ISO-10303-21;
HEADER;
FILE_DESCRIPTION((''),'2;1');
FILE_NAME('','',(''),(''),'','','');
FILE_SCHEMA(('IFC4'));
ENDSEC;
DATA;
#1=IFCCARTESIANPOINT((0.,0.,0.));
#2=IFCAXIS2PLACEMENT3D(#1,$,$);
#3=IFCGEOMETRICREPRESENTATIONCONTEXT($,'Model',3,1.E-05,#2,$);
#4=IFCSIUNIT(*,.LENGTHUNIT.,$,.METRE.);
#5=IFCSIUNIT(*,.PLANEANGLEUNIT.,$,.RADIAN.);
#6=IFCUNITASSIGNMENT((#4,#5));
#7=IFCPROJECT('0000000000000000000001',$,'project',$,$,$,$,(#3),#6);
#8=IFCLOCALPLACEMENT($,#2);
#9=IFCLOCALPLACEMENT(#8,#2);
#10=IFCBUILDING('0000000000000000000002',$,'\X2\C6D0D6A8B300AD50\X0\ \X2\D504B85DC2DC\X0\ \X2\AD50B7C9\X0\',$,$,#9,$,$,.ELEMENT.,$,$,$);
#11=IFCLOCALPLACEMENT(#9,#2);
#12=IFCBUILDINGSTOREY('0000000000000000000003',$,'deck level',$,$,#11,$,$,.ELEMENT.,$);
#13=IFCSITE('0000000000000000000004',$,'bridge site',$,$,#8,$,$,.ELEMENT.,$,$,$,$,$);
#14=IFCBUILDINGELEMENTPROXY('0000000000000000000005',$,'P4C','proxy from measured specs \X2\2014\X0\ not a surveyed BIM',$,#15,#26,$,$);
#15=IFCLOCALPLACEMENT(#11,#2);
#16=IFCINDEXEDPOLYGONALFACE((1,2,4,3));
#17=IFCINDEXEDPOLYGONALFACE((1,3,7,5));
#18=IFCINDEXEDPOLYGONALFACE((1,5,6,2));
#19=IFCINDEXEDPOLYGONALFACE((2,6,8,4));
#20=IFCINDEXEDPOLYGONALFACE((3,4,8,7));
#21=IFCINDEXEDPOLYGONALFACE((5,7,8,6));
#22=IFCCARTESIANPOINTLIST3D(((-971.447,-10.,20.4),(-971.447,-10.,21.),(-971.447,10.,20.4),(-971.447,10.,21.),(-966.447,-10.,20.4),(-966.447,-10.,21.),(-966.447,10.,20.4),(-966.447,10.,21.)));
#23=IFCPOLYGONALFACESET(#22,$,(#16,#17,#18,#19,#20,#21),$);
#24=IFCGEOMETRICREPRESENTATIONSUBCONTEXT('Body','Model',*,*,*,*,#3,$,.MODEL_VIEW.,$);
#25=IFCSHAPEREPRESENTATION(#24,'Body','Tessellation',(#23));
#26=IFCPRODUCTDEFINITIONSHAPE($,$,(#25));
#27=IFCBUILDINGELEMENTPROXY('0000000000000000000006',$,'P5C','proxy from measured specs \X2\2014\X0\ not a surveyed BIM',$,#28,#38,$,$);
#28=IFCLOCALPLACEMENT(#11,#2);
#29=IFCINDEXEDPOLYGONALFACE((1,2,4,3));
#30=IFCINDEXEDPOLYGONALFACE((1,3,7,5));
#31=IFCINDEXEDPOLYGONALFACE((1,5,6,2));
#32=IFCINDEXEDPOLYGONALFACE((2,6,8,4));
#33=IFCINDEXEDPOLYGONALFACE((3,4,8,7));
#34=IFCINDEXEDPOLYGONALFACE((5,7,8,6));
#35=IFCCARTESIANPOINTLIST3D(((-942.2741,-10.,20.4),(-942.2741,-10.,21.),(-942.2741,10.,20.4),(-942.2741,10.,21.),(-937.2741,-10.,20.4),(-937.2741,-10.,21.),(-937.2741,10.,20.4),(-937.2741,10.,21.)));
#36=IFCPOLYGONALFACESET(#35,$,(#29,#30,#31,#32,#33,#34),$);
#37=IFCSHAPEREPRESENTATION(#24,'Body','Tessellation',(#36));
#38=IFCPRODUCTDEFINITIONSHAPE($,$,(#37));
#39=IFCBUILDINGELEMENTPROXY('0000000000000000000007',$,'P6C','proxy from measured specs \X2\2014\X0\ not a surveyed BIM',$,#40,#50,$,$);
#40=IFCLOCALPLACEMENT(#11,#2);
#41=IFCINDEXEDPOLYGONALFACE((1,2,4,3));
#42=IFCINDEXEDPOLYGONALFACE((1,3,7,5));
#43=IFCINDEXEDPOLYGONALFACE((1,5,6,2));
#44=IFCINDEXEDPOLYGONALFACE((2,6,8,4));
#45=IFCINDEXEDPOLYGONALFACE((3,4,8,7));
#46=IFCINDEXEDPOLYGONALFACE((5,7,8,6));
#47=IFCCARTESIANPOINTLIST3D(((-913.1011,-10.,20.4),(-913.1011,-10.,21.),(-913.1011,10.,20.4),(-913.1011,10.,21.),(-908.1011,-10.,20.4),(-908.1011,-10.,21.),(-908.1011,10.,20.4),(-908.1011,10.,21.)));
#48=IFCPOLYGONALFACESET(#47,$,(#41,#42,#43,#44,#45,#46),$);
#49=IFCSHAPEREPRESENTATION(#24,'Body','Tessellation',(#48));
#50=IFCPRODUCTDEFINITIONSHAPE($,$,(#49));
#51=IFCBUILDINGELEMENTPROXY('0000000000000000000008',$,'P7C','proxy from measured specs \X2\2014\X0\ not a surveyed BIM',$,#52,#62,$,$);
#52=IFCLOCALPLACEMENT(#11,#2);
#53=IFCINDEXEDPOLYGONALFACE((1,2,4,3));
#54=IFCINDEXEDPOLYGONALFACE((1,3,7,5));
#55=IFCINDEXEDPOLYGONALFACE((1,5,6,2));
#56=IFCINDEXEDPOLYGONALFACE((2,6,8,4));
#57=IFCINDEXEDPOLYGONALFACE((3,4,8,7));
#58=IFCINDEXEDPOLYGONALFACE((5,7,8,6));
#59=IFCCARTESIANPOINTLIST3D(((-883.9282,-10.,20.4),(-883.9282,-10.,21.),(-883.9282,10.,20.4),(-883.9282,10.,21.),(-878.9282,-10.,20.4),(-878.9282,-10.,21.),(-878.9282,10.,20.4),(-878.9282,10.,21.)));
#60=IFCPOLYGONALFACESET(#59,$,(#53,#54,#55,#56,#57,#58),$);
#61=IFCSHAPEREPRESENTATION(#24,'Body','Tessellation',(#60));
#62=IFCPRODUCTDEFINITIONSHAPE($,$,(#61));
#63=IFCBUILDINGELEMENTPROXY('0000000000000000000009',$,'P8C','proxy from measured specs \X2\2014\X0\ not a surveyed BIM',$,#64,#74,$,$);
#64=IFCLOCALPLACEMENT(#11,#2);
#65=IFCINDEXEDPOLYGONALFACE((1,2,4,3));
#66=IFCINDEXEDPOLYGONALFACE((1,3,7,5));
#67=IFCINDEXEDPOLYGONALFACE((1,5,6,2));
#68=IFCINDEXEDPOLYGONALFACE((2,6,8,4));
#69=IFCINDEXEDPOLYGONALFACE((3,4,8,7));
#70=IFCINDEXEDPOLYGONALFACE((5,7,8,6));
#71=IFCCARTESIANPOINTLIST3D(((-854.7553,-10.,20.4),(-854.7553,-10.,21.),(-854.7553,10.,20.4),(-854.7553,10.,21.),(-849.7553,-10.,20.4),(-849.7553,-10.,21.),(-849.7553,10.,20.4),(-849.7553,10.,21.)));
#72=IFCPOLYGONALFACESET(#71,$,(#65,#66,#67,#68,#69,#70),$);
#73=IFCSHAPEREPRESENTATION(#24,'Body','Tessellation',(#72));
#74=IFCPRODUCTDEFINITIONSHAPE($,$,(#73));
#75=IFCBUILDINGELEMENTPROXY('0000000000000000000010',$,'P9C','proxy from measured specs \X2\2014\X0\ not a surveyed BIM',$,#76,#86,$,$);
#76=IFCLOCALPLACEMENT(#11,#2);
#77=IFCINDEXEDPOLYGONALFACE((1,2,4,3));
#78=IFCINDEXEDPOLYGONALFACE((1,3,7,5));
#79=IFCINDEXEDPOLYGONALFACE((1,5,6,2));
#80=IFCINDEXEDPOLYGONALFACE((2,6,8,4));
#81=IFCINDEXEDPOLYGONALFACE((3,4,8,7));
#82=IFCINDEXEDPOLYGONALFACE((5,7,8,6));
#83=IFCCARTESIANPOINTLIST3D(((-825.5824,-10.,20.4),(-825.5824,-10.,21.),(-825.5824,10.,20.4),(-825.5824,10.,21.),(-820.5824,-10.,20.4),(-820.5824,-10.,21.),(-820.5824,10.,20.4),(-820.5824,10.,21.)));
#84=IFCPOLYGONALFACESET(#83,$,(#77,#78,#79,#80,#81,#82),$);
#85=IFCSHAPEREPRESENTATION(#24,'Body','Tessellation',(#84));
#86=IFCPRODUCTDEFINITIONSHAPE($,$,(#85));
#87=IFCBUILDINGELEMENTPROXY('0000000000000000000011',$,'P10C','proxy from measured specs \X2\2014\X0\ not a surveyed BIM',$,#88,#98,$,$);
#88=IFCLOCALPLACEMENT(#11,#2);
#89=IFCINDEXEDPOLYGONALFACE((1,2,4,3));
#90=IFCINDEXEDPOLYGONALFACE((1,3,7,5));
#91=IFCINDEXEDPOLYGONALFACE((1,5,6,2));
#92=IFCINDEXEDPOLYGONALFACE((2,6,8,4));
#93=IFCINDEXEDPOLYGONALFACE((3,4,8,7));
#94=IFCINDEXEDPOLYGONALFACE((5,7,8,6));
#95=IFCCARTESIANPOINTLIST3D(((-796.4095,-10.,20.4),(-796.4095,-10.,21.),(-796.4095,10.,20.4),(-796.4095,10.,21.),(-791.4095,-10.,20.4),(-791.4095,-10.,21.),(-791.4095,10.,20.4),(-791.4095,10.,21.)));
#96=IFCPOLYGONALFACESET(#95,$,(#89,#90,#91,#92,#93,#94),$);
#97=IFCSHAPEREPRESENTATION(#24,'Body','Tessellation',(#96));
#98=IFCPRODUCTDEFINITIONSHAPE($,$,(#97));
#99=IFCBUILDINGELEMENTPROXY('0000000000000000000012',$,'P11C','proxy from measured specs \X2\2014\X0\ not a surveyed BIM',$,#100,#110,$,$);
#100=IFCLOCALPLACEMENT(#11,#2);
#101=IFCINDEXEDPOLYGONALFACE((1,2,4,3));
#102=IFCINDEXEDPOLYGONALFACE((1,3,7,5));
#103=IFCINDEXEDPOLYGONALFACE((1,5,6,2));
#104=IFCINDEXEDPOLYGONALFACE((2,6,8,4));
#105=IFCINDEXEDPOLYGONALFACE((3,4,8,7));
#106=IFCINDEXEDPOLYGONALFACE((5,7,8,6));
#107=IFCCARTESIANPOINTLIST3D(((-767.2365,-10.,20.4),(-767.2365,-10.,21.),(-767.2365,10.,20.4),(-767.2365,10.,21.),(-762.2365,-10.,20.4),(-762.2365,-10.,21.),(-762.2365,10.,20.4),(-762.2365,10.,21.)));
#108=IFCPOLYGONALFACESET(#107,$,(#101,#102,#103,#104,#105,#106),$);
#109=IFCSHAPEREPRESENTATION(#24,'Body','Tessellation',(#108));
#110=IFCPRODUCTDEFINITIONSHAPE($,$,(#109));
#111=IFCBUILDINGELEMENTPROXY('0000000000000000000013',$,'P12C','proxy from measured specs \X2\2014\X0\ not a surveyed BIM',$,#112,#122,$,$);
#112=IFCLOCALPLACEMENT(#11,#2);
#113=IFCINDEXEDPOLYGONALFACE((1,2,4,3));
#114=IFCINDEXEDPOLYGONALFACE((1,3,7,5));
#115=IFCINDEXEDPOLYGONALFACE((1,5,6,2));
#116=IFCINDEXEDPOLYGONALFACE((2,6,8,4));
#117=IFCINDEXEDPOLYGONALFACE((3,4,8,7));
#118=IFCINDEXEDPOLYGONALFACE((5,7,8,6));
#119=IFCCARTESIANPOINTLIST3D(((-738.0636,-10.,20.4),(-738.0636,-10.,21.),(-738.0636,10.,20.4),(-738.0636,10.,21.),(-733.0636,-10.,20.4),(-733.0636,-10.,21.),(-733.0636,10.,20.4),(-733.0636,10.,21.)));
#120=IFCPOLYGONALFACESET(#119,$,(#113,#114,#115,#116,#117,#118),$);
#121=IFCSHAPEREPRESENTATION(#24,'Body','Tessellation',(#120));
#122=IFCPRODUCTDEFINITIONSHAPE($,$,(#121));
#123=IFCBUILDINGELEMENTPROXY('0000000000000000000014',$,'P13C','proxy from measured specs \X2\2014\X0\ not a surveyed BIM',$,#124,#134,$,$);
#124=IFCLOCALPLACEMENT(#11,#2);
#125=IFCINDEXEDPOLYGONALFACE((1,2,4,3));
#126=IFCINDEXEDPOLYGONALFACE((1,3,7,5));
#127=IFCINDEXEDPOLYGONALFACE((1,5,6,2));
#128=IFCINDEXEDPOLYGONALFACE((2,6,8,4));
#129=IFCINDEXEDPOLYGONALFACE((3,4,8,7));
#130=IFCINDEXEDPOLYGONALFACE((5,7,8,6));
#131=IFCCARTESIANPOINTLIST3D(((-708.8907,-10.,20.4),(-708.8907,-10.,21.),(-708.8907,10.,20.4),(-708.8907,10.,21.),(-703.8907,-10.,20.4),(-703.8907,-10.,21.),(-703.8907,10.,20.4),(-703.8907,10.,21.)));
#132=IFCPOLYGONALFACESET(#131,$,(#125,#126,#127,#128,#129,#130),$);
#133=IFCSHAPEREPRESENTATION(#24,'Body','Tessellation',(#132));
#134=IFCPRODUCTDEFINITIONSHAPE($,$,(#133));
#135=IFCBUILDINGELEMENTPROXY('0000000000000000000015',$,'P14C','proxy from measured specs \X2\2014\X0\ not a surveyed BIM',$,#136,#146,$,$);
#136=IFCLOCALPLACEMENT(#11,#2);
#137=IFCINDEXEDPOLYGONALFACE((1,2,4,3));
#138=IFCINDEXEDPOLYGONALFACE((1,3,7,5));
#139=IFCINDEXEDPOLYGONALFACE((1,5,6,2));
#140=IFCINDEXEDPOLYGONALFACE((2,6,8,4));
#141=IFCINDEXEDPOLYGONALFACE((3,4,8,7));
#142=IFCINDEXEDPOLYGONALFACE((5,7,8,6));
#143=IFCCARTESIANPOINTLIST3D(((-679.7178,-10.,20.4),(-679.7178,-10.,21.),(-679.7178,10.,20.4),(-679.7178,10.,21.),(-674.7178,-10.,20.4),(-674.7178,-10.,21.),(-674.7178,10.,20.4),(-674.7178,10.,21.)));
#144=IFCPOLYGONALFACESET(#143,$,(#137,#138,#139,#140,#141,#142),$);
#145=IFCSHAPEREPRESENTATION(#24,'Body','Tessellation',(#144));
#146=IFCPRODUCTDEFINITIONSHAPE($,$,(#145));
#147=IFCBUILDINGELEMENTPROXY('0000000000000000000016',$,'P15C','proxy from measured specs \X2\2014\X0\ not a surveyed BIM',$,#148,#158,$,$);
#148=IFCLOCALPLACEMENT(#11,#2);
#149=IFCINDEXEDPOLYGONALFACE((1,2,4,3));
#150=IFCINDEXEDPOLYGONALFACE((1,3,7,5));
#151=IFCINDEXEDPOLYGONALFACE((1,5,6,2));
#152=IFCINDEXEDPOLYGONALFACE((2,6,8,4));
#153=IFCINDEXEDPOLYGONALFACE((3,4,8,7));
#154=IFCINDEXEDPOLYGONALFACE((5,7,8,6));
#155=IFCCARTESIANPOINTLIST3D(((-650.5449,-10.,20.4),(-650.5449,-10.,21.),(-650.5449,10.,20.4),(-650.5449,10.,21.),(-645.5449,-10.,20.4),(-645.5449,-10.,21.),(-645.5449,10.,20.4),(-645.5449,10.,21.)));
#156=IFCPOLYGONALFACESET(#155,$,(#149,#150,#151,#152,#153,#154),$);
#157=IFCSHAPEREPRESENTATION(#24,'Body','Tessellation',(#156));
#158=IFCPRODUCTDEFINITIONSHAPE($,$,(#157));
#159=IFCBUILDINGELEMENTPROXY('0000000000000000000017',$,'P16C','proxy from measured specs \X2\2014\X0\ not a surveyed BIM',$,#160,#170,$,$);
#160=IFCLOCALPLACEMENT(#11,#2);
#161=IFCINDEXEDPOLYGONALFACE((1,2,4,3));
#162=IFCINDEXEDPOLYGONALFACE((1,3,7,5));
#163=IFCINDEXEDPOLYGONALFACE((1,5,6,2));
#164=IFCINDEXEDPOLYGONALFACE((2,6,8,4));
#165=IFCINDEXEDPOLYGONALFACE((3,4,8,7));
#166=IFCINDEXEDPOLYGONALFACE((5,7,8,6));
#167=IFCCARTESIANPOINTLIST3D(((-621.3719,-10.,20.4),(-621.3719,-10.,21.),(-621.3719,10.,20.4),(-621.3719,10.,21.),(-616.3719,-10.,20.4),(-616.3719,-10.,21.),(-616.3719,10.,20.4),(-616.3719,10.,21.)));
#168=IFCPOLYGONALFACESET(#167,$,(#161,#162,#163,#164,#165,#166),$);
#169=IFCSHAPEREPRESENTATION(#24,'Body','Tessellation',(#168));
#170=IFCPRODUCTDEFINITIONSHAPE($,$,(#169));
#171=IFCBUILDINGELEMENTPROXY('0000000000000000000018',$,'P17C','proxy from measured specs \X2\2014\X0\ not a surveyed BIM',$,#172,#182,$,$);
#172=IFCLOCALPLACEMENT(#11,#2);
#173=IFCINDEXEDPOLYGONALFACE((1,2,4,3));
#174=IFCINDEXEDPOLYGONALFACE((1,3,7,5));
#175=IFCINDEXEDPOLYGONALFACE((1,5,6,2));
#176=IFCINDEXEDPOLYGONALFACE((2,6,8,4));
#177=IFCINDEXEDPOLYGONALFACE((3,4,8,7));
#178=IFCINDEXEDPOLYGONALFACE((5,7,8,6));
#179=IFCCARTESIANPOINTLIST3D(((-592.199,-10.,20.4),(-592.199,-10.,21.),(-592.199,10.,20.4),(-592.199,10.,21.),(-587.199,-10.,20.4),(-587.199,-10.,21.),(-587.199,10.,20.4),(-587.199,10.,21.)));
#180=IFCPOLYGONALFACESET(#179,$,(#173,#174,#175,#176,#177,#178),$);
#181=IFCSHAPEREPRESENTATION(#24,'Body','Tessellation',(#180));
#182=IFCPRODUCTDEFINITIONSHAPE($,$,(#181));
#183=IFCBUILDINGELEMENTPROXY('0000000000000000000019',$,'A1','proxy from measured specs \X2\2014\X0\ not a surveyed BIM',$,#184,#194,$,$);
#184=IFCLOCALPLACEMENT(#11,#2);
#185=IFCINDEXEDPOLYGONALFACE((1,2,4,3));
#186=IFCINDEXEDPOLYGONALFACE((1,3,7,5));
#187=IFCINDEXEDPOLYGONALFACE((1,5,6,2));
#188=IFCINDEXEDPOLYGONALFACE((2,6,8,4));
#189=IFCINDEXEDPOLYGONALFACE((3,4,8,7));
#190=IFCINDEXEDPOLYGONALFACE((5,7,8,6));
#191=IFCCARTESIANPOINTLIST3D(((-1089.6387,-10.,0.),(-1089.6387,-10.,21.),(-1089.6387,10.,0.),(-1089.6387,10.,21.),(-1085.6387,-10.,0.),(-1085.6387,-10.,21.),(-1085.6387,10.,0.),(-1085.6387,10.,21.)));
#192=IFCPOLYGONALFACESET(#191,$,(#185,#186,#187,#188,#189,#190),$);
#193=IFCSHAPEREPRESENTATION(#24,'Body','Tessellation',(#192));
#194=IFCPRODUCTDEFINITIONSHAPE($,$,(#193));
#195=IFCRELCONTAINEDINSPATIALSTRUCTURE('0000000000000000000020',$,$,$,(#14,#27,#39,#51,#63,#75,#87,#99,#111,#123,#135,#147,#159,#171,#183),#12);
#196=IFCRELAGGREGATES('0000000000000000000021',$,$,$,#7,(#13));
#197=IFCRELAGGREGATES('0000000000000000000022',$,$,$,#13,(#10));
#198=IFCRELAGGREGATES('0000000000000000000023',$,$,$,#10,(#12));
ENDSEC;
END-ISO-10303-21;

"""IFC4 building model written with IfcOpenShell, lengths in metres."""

from ifc_helpers import new_model, si_unit, frame, origin, origin_2d, place, context, subcontext, project, spatial, rectangle, extrude, element, save


model = new_model("IFC4")

# Units and contexts
model_context = context("Model", 3, precision=1e-05, world=origin())
body_context = subcontext(model_context, "Body", "Model", "MODEL_VIEW")
ifc_project = project(units=[si_unit("LENGTHUNIT", "METRE"), si_unit("PLANEANGLEUNIT", "RADIAN")], contexts=[model_context])

# Site, building, storey
site_placement = place(None, origin())
site = spatial("IfcSite", under=ifc_project, at=site_placement, Name="bridge site", CompositionType="ELEMENT")
building_placement = place(site_placement, origin())
building = spatial("IfcBuilding", under=site, at=building_placement, Name="원효대교 프록시 교량", CompositionType="ELEMENT")
storey_placement = place(building_placement, origin())
storey = spatial("IfcBuildingStorey", under=building, at=storey_placement, Name="deck level", CompositionType="ELEMENT")

# Building element proxies
for number, where, name in (
    (1, (-968.947, 0.0, 20.4), "P4C"),
    (2, (-939.7741, 0.0, 20.4), "P5C"),
    (3, (-910.6011, 0.0, 20.4), "P6C"),
    (4, (-881.4282, 0.0, 20.4), "P7C"),
    (5, (-852.2553, 0.0, 20.4), "P8C"),
    (6, (-823.0824, 0.0, 20.4), "P9C"),
    (7, (-793.9095, 0.0, 20.4), "P10C"),
    (8, (-764.7365, 0.0, 20.4), "P11C"),
    (9, (-735.5636, 0.0, 20.4), "P12C"),
    (10, (-706.3907, 0.0, 20.4), "P13C"),
    (11, (-677.2178, 0.0, 20.4), "P14C"),
    (12, (-648.0449, 0.0, 20.4), "P15C"),
    (13, (-618.8719, 0.0, 20.4), "P16C"),
    (14, (-589.699, 0.0, 20.4), "P17C"),
):
    element("IfcBuildingElementProxy", number, at=place(storey_placement, frame(where)), inside=storey, Name=name, Description="proxy from measured specs — not a surveyed BIM", context=body_context, shape_type="SweptSolid", body=[
        extrude(rectangle(XDim=5.0, YDim=20.0, at=origin_2d()), origin(), (0.0, 0.0, 1.0), 0.6),
    ])
proxy_placement = place(storey_placement, frame((-1087.6387, 0.0, 0.0)))
element("IfcBuildingElementProxy", 15, at=proxy_placement, inside=storey, Name="A1", Description="proxy from measured specs — not a surveyed BIM", context=body_context, shape_type="SweptSolid", body=[
    extrude(rectangle(XDim=4.0, YDim=20.0, at=origin_2d()), origin(), (0.0, 0.0, 1.0), 21.0),
])

save(model, "model.ifc")
